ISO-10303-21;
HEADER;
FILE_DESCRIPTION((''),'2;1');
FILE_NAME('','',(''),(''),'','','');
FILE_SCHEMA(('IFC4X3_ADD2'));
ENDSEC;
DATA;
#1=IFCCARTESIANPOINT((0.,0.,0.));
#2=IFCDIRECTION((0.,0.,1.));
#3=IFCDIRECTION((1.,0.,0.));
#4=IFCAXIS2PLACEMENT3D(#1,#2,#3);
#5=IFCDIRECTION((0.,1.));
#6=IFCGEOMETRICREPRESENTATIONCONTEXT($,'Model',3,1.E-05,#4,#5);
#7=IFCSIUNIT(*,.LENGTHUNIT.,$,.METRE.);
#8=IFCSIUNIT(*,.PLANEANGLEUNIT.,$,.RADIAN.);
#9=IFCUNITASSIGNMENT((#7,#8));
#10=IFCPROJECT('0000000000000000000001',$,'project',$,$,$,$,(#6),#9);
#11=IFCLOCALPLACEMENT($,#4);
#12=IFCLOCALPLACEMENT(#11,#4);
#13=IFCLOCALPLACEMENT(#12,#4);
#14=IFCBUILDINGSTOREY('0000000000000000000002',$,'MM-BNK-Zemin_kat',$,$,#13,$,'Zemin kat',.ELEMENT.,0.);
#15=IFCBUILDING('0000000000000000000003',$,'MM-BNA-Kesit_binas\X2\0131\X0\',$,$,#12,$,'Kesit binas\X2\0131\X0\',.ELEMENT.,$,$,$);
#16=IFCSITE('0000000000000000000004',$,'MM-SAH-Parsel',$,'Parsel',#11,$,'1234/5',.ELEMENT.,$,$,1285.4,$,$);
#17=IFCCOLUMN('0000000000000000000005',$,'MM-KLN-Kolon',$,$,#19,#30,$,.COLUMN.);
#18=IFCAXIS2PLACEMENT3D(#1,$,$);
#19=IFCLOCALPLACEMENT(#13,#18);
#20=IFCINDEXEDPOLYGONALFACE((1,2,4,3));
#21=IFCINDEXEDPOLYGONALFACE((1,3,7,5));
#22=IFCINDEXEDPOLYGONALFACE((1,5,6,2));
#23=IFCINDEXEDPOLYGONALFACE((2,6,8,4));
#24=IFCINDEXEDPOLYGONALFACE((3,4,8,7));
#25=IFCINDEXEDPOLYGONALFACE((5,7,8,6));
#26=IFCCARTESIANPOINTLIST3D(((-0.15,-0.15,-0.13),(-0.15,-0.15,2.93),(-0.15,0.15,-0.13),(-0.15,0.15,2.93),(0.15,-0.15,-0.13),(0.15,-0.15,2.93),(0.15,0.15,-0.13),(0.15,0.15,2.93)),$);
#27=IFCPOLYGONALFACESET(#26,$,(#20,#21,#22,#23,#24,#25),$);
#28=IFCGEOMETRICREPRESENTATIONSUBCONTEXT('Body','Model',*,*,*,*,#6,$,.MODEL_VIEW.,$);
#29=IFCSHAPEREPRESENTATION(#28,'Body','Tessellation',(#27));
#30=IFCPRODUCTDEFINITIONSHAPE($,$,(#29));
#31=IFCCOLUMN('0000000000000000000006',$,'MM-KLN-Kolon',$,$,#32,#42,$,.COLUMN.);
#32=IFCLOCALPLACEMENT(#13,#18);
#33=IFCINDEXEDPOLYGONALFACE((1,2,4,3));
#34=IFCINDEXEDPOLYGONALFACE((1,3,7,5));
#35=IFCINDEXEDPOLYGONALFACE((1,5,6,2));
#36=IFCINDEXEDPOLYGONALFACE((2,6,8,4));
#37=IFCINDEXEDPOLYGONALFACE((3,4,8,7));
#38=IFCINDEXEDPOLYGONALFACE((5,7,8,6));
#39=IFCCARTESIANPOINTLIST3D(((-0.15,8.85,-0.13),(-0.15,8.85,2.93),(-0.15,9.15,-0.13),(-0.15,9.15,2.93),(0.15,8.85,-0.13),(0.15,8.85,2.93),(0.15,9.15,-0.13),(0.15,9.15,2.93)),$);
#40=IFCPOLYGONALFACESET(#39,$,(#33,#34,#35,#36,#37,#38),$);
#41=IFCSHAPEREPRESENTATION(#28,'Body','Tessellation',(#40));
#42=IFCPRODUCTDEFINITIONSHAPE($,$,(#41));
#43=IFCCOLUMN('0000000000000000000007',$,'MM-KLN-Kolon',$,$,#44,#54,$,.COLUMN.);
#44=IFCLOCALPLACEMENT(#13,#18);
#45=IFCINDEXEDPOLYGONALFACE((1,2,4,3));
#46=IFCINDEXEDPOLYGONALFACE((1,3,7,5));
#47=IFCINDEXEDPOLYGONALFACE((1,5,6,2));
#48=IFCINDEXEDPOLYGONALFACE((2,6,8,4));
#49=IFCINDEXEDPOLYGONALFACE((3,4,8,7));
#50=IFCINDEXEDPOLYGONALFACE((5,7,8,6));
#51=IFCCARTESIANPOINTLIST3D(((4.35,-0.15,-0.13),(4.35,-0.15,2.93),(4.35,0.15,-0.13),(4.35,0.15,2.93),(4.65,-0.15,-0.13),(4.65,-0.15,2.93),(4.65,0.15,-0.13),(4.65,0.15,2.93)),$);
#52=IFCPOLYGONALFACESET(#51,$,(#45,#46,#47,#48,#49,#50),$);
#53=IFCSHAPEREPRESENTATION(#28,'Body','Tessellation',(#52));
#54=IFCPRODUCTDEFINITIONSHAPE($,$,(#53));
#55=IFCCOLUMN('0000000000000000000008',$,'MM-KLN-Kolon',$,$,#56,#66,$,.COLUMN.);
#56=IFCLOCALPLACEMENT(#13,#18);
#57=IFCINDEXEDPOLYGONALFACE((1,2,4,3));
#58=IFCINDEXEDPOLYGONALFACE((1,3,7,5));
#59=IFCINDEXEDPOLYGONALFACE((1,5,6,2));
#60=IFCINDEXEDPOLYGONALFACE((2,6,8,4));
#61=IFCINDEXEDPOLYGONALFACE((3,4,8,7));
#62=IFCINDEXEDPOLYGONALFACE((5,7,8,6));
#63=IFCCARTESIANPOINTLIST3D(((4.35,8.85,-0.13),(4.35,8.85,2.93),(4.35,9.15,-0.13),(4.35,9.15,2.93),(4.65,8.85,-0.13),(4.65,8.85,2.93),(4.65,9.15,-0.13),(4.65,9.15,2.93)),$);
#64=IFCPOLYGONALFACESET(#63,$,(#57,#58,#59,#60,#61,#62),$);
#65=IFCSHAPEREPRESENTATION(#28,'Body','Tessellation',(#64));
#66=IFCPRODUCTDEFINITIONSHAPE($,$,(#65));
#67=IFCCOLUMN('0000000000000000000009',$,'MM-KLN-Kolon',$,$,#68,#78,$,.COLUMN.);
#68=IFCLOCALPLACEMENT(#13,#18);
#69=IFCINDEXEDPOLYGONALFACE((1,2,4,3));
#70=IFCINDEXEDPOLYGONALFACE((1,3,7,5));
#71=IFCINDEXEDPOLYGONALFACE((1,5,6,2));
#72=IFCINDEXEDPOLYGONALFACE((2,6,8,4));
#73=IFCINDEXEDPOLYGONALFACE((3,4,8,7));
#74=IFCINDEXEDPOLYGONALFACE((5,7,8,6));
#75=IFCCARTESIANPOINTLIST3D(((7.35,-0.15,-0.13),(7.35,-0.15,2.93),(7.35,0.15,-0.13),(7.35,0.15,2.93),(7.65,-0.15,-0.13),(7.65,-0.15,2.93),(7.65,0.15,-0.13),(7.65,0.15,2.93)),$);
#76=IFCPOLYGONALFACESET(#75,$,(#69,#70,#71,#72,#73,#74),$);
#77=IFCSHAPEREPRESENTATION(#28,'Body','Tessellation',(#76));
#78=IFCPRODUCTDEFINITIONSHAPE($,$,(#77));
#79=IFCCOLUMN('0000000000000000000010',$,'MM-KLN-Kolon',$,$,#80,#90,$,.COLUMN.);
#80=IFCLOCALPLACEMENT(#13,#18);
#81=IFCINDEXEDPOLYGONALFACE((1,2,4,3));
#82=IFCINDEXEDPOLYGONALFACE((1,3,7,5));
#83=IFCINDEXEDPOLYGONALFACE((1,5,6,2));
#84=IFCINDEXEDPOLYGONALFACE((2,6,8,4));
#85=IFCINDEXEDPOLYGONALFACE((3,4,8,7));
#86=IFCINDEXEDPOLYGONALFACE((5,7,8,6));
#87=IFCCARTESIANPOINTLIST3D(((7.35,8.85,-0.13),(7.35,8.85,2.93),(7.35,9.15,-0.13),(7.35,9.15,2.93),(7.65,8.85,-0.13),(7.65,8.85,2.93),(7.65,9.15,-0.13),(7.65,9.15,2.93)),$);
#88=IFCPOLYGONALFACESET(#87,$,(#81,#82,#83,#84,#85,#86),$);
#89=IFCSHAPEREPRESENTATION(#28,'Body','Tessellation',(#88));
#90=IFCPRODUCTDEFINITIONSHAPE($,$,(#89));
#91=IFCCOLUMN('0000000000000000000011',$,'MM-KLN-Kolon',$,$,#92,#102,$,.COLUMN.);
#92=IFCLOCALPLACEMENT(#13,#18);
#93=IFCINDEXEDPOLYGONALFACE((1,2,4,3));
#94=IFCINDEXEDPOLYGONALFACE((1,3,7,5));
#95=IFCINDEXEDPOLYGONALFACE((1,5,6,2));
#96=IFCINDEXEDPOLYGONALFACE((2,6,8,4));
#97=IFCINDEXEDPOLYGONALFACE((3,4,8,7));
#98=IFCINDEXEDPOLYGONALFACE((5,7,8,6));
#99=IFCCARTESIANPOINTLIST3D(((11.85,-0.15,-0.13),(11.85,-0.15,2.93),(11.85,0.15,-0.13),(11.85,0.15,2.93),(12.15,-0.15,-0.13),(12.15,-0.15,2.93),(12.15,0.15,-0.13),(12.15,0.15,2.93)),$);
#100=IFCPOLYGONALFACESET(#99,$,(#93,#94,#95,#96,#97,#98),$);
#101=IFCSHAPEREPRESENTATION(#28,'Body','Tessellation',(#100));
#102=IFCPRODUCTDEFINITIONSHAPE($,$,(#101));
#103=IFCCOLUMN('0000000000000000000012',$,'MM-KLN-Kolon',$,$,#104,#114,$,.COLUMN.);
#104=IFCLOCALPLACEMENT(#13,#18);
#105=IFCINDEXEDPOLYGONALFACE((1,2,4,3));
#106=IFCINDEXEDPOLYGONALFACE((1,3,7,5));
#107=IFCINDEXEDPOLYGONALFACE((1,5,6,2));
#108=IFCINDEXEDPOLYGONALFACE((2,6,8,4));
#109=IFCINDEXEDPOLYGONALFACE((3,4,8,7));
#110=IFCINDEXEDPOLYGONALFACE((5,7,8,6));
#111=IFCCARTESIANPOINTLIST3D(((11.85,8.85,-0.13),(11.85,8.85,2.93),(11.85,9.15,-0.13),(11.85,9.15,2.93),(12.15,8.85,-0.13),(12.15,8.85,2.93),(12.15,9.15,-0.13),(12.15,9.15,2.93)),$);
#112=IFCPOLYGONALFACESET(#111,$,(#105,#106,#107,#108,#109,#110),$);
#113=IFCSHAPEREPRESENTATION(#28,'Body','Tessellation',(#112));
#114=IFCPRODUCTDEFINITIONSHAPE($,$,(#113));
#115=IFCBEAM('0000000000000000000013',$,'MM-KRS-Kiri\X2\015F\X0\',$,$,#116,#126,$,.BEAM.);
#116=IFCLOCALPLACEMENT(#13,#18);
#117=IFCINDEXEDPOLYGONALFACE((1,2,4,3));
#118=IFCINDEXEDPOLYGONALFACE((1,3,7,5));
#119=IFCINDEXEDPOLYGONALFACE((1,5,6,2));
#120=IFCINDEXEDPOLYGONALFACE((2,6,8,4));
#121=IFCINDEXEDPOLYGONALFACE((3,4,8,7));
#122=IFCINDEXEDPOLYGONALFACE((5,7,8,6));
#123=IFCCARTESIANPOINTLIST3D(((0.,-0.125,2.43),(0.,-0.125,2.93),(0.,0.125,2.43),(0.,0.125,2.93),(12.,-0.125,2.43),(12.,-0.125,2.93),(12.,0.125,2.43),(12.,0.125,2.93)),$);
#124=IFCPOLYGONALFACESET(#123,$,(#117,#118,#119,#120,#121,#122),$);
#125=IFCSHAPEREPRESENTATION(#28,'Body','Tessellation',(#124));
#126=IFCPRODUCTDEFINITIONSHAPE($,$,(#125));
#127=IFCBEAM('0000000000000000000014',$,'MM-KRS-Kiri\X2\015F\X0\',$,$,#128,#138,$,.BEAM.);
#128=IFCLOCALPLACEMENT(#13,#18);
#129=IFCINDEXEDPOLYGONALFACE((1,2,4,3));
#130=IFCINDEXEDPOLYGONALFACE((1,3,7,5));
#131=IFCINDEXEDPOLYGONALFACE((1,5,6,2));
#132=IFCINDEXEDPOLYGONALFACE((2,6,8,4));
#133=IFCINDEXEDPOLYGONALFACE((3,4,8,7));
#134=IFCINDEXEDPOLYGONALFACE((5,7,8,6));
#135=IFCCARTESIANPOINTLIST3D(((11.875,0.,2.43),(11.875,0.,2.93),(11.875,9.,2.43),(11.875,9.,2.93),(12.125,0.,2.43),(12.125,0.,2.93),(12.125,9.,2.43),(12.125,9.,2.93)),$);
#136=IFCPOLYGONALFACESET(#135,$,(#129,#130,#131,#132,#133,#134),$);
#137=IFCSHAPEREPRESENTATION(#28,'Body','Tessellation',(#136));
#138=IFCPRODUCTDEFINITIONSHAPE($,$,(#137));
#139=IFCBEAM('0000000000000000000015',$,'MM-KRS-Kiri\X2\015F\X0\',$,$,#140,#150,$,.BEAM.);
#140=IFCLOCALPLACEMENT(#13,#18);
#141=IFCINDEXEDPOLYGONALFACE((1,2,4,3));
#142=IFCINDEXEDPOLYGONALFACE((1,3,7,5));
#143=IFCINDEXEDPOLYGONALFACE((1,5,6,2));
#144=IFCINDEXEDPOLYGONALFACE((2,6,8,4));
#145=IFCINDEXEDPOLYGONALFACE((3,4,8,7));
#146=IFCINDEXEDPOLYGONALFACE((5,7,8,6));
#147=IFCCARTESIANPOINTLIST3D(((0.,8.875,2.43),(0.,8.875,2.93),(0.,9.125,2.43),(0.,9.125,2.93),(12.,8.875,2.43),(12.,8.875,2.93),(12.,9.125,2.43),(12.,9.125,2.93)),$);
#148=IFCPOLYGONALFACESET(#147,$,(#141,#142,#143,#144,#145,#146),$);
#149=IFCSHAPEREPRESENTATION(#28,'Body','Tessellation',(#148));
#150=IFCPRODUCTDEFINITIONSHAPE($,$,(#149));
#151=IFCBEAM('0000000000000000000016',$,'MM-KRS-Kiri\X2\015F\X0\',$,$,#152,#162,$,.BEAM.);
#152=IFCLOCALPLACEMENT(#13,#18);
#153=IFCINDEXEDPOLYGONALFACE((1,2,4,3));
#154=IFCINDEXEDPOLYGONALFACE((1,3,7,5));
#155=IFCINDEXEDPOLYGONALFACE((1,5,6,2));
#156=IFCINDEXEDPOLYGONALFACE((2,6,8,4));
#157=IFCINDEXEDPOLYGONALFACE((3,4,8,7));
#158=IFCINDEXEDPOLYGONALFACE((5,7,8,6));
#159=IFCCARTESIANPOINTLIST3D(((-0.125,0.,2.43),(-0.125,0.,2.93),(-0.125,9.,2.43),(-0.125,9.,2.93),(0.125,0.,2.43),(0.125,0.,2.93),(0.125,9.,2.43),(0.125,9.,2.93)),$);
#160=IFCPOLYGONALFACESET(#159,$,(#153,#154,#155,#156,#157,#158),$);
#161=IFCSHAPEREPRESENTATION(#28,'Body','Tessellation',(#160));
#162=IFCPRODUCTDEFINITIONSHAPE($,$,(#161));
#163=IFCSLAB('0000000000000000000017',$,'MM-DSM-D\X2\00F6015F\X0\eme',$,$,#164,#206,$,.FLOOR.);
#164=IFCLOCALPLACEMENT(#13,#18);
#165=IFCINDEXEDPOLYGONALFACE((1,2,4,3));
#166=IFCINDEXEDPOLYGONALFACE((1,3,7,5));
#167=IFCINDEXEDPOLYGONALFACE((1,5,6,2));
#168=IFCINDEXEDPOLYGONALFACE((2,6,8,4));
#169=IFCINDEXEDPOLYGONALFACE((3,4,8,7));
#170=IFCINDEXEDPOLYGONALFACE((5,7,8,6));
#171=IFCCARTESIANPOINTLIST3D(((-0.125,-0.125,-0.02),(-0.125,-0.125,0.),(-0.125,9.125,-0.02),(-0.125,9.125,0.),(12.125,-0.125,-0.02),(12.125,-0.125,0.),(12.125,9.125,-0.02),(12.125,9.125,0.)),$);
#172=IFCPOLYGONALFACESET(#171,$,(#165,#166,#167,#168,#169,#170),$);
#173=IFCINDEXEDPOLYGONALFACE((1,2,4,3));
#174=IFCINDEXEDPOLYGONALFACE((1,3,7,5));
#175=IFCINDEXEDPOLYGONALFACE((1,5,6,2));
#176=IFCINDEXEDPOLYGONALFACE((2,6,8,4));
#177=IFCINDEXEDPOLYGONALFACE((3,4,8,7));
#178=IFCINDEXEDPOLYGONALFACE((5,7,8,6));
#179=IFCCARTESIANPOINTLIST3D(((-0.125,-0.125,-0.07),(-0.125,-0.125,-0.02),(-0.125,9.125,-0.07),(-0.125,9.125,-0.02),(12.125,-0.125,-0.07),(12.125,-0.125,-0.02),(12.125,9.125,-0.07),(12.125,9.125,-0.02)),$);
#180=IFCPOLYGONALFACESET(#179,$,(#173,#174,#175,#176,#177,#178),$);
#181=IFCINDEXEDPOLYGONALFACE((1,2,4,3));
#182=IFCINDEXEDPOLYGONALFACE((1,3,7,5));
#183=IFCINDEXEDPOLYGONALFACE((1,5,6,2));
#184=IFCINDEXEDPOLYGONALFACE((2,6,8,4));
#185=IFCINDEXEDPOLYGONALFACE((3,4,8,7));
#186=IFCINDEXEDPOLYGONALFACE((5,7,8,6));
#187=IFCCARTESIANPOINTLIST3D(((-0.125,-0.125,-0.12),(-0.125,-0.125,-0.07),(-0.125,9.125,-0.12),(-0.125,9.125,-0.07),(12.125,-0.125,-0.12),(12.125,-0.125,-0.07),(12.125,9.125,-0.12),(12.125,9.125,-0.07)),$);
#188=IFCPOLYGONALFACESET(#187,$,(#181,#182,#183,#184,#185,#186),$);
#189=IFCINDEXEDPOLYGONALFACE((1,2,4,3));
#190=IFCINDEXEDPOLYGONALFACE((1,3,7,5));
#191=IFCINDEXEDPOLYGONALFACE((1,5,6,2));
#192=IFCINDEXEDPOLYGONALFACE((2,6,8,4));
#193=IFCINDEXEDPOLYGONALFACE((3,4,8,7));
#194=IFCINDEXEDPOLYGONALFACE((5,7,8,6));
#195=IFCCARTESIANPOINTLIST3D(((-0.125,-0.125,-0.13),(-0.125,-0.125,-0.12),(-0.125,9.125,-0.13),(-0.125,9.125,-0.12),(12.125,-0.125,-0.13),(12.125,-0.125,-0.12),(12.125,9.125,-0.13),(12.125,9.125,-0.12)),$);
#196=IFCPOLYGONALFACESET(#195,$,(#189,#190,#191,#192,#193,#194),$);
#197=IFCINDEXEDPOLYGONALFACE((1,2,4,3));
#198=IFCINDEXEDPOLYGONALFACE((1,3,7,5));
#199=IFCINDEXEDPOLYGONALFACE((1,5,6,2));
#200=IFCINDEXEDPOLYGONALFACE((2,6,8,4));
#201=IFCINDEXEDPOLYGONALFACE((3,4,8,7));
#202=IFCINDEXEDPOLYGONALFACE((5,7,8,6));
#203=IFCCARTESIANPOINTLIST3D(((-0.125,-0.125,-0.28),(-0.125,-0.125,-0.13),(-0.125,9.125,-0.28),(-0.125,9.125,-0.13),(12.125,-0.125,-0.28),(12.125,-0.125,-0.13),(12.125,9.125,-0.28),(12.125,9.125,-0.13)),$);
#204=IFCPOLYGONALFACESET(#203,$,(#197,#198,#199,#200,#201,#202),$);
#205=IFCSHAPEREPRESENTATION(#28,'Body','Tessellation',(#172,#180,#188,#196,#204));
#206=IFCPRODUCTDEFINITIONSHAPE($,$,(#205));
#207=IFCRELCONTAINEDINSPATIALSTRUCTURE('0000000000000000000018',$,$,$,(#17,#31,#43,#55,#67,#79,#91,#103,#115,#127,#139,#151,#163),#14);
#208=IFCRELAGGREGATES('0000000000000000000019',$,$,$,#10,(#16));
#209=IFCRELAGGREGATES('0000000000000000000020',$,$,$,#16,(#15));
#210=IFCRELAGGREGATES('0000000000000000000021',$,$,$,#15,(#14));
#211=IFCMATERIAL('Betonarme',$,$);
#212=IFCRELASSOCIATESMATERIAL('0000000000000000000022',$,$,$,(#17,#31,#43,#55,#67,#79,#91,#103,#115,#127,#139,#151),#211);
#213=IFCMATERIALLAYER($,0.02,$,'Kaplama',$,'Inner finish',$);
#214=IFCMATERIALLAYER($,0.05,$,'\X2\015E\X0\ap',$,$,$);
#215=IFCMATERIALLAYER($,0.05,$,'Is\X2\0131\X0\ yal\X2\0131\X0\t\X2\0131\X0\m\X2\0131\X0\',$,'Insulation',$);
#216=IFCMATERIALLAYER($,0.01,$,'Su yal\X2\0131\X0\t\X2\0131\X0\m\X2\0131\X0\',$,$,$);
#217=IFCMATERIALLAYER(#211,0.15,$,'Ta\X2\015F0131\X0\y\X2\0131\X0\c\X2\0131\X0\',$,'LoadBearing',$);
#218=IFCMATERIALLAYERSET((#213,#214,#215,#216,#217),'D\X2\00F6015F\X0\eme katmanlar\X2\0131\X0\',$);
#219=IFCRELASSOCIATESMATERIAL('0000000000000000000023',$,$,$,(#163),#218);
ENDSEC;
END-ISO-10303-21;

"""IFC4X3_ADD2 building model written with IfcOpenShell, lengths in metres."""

from ifc_helpers import new_model, si_unit, direction, frame, origin_with_axes, place, context, subcontext, project, spatial, polyline, outline, extrude, material, layer, layer_set, layer_usage, element, save


model = new_model("IFC4X3_ADD2")

# Units and contexts
model_context = context("Model", 3, precision=1e-05, world=origin_with_axes(), true_north=direction((0.0, 1.0)))
body_context = subcontext(model_context, "Body", "Model", "MODEL_VIEW")
ifc_project = project(units=[si_unit("LENGTHUNIT", "METRE"), si_unit("PLANEANGLEUNIT", "RADIAN")], contexts=[model_context])

# Site, building, storey
site_placement = place(None, origin_with_axes())
site = spatial("IfcSite", under=ifc_project, at=site_placement, Name="MM-SAH-Parsel", ObjectType="Parsel", LongName="1234/5", CompositionType="ELEMENT", RefElevation=1285.4)
building_placement = place(site_placement, origin_with_axes())
building = spatial("IfcBuilding", under=site, at=building_placement, Name="MM-BNA-Kesit_binası", LongName="Kesit binası", CompositionType="ELEMENT")
storey_placement = place(building_placement, origin_with_axes())
storey = spatial("IfcBuildingStorey", under=building, at=storey_placement, Name="MM-BNK-Zemin_kat", LongName="Zemin kat", CompositionType="ELEMENT", Elevation=0.0)

# Columns
ifc_material_1 = material(Name="Betonarme")
column_1_placement = place(storey_placement, origin_with_axes())
element("IfcColumn", 1, at=column_1_placement, inside=storey, material=ifc_material_1, Name="MM-KLN-Kolon", PredefinedType="COLUMN", context=body_context, shape_type="SweptSolid", body=[
    extrude(outline(polyline([(-0.15, -0.15), (0.15, -0.15), (0.15, 0.15), (-0.15, 0.15), (-0.15, -0.15)])), frame((0.0, 0.0, -0.13)), (0.0, 0.0, 1.0), 3.06),
])
column_2_placement = place(storey_placement, origin_with_axes())
element("IfcColumn", 2, at=column_2_placement, inside=storey, material=ifc_material_1, Name="MM-KLN-Kolon", PredefinedType="COLUMN", context=body_context, shape_type="SweptSolid", body=[
    extrude(outline(polyline([(-0.15, 8.85), (0.15, 8.85), (0.15, 9.15), (-0.15, 9.15), (-0.15, 8.85)])), frame((0.0, 0.0, -0.13)), (0.0, 0.0, 1.0), 3.06),
])
column_3_placement = place(storey_placement, origin_with_axes())
element("IfcColumn", 3, at=column_3_placement, inside=storey, material=ifc_material_1, Name="MM-KLN-Kolon", PredefinedType="COLUMN", context=body_context, shape_type="SweptSolid", body=[
    extrude(outline(polyline([(4.35, -0.15), (4.65, -0.15), (4.65, 0.15), (4.35, 0.15), (4.35, -0.15)])), frame((0.0, 0.0, -0.13)), (0.0, 0.0, 1.0), 3.06),
])
column_4_placement = place(storey_placement, origin_with_axes())
element("IfcColumn", 4, at=column_4_placement, inside=storey, material=ifc_material_1, Name="MM-KLN-Kolon", PredefinedType="COLUMN", context=body_context, shape_type="SweptSolid", body=[
    extrude(outline(polyline([(4.35, 8.85), (4.65, 8.85), (4.65, 9.15), (4.35, 9.15), (4.35, 8.85)])), frame((0.0, 0.0, -0.13)), (0.0, 0.0, 1.0), 3.06),
])
column_5_placement = place(storey_placement, origin_with_axes())
element("IfcColumn", 5, at=column_5_placement, inside=storey, material=ifc_material_1, Name="MM-KLN-Kolon", PredefinedType="COLUMN", context=body_context, shape_type="SweptSolid", body=[
    extrude(outline(polyline([(7.35, -0.15), (7.65, -0.15), (7.65, 0.15), (7.35, 0.15), (7.35, -0.15)])), frame((0.0, 0.0, -0.13)), (0.0, 0.0, 1.0), 3.06),
])
column_6_placement = place(storey_placement, origin_with_axes())
element("IfcColumn", 6, at=column_6_placement, inside=storey, material=ifc_material_1, Name="MM-KLN-Kolon", PredefinedType="COLUMN", context=body_context, shape_type="SweptSolid", body=[
    extrude(outline(polyline([(7.35, 8.85), (7.65, 8.85), (7.65, 9.15), (7.35, 9.15), (7.35, 8.85)])), frame((0.0, 0.0, -0.13)), (0.0, 0.0, 1.0), 3.06),
])
column_7_placement = place(storey_placement, origin_with_axes())
element("IfcColumn", 7, at=column_7_placement, inside=storey, material=ifc_material_1, Name="MM-KLN-Kolon", PredefinedType="COLUMN", context=body_context, shape_type="SweptSolid", body=[
    extrude(outline(polyline([(11.85, -0.15), (12.15, -0.15), (12.15, 0.15), (11.85, 0.15), (11.85, -0.15)])), frame((0.0, 0.0, -0.13)), (0.0, 0.0, 1.0), 3.06),
])
column_8_placement = place(storey_placement, origin_with_axes())
element("IfcColumn", 8, at=column_8_placement, inside=storey, material=ifc_material_1, Name="MM-KLN-Kolon", PredefinedType="COLUMN", context=body_context, shape_type="SweptSolid", body=[
    extrude(outline(polyline([(11.85, 8.85), (12.15, 8.85), (12.15, 9.15), (11.85, 9.15), (11.85, 8.85)])), frame((0.0, 0.0, -0.13)), (0.0, 0.0, 1.0), 3.06),
])

# Beams
beam_1_placement = place(storey_placement, origin_with_axes())
element("IfcBeam", 9, at=beam_1_placement, inside=storey, material=ifc_material_1, Name="MM-KRS-Kiriş", PredefinedType="BEAM", context=body_context, shape_type="SweptSolid", body=[
    extrude(outline(polyline([(0.0, 0.125), (12.0, 0.125), (12.0, -0.125), (0.0, -0.125), (0.0, 0.125)])), frame((0.0, 0.0, 2.43)), (0.0, 0.0, 1.0), 0.5),
])
beam_2_placement = place(storey_placement, origin_with_axes())
element("IfcBeam", 10, at=beam_2_placement, inside=storey, material=ifc_material_1, Name="MM-KRS-Kiriş", PredefinedType="BEAM", context=body_context, shape_type="SweptSolid", body=[
    extrude(outline(polyline([(11.875, 0.0), (11.875, 9.0), (12.125, 9.0), (12.125, 0.0), (11.875, 0.0)])), frame((0.0, 0.0, 2.43)), (0.0, 0.0, 1.0), 0.5),
])
beam_3_placement = place(storey_placement, origin_with_axes())
element("IfcBeam", 11, at=beam_3_placement, inside=storey, material=ifc_material_1, Name="MM-KRS-Kiriş", PredefinedType="BEAM", context=body_context, shape_type="SweptSolid", body=[
    extrude(outline(polyline([(12.0, 8.875), (0.0, 8.875), (0.0, 9.125), (12.0, 9.125), (12.0, 8.875)])), frame((0.0, 0.0, 2.43)), (0.0, 0.0, 1.0), 0.5),
])
beam_4_placement = place(storey_placement, origin_with_axes())
element("IfcBeam", 12, at=beam_4_placement, inside=storey, material=ifc_material_1, Name="MM-KRS-Kiriş", PredefinedType="BEAM", context=body_context, shape_type="SweptSolid", body=[
    extrude(outline(polyline([(0.125, 9.0), (0.125, 0.0), (-0.125, 0.0), (-0.125, 9.0), (0.125, 9.0)])), frame((0.0, 0.0, 2.43)), (0.0, 0.0, 1.0), 0.5),
])

# Slab
ifc_layer_1 = layer(None, 0.02, Name="Kaplama", Category="Inner finish")
ifc_layer_2 = layer(None, 0.05, Name="Şap")
ifc_layer_3 = layer(None, 0.05, Name="Isı yalıtımı", Category="Insulation")
ifc_layer_4 = layer(None, 0.01, Name="Su yalıtımı")
ifc_layer_5 = layer(ifc_material_1, 0.15, Name="Taşıyıcı", Category="LoadBearing")
ifc_layer_set_1 = layer_set([ifc_layer_1, ifc_layer_2, ifc_layer_3, ifc_layer_4, ifc_layer_5], Name="Döşeme katmanları")
ifc_layer_usage = layer_usage(ifc_layer_set_1, "AXIS3", "NEGATIVE", 0.0)
slab_placement = place(storey_placement, origin_with_axes())
element("IfcSlab", 13, at=slab_placement, inside=storey, material=ifc_layer_usage, Name="MM-DSM-Döşeme", PredefinedType="FLOOR", context=body_context, shape_type="SweptSolid", body=[
    extrude(outline(polyline([(-0.125, -0.125), (12.125, -0.125), (12.125, 9.125), (-0.125, 9.125), (-0.125, -0.125)])), frame((0.0, 0.0, -0.02)), (0.0, 0.0, 1.0), 0.02),
    extrude(outline(polyline([(-0.125, -0.125), (12.125, -0.125), (12.125, 9.125), (-0.125, 9.125), (-0.125, -0.125)])), frame((0.0, 0.0, -0.07)), (0.0, 0.0, 1.0), 0.05),
    extrude(outline(polyline([(-0.125, -0.125), (12.125, -0.125), (12.125, 9.125), (-0.125, 9.125), (-0.125, -0.125)])), frame((0.0, 0.0, -0.12)), (0.0, 0.0, 1.0), 0.05),
    extrude(outline(polyline([(-0.125, -0.125), (12.125, -0.125), (12.125, 9.125), (-0.125, 9.125), (-0.125, -0.125)])), frame((0.0, 0.0, -0.13)), (0.0, 0.0, 1.0), 0.01),
    extrude(outline(polyline([(-0.125, -0.125), (12.125, -0.125), (12.125, 9.125), (-0.125, 9.125), (-0.125, -0.125)])), frame((0.0, 0.0, -0.28)), (0.0, 0.0, 1.0), 0.15),
])

save(model, "model.ifc")
